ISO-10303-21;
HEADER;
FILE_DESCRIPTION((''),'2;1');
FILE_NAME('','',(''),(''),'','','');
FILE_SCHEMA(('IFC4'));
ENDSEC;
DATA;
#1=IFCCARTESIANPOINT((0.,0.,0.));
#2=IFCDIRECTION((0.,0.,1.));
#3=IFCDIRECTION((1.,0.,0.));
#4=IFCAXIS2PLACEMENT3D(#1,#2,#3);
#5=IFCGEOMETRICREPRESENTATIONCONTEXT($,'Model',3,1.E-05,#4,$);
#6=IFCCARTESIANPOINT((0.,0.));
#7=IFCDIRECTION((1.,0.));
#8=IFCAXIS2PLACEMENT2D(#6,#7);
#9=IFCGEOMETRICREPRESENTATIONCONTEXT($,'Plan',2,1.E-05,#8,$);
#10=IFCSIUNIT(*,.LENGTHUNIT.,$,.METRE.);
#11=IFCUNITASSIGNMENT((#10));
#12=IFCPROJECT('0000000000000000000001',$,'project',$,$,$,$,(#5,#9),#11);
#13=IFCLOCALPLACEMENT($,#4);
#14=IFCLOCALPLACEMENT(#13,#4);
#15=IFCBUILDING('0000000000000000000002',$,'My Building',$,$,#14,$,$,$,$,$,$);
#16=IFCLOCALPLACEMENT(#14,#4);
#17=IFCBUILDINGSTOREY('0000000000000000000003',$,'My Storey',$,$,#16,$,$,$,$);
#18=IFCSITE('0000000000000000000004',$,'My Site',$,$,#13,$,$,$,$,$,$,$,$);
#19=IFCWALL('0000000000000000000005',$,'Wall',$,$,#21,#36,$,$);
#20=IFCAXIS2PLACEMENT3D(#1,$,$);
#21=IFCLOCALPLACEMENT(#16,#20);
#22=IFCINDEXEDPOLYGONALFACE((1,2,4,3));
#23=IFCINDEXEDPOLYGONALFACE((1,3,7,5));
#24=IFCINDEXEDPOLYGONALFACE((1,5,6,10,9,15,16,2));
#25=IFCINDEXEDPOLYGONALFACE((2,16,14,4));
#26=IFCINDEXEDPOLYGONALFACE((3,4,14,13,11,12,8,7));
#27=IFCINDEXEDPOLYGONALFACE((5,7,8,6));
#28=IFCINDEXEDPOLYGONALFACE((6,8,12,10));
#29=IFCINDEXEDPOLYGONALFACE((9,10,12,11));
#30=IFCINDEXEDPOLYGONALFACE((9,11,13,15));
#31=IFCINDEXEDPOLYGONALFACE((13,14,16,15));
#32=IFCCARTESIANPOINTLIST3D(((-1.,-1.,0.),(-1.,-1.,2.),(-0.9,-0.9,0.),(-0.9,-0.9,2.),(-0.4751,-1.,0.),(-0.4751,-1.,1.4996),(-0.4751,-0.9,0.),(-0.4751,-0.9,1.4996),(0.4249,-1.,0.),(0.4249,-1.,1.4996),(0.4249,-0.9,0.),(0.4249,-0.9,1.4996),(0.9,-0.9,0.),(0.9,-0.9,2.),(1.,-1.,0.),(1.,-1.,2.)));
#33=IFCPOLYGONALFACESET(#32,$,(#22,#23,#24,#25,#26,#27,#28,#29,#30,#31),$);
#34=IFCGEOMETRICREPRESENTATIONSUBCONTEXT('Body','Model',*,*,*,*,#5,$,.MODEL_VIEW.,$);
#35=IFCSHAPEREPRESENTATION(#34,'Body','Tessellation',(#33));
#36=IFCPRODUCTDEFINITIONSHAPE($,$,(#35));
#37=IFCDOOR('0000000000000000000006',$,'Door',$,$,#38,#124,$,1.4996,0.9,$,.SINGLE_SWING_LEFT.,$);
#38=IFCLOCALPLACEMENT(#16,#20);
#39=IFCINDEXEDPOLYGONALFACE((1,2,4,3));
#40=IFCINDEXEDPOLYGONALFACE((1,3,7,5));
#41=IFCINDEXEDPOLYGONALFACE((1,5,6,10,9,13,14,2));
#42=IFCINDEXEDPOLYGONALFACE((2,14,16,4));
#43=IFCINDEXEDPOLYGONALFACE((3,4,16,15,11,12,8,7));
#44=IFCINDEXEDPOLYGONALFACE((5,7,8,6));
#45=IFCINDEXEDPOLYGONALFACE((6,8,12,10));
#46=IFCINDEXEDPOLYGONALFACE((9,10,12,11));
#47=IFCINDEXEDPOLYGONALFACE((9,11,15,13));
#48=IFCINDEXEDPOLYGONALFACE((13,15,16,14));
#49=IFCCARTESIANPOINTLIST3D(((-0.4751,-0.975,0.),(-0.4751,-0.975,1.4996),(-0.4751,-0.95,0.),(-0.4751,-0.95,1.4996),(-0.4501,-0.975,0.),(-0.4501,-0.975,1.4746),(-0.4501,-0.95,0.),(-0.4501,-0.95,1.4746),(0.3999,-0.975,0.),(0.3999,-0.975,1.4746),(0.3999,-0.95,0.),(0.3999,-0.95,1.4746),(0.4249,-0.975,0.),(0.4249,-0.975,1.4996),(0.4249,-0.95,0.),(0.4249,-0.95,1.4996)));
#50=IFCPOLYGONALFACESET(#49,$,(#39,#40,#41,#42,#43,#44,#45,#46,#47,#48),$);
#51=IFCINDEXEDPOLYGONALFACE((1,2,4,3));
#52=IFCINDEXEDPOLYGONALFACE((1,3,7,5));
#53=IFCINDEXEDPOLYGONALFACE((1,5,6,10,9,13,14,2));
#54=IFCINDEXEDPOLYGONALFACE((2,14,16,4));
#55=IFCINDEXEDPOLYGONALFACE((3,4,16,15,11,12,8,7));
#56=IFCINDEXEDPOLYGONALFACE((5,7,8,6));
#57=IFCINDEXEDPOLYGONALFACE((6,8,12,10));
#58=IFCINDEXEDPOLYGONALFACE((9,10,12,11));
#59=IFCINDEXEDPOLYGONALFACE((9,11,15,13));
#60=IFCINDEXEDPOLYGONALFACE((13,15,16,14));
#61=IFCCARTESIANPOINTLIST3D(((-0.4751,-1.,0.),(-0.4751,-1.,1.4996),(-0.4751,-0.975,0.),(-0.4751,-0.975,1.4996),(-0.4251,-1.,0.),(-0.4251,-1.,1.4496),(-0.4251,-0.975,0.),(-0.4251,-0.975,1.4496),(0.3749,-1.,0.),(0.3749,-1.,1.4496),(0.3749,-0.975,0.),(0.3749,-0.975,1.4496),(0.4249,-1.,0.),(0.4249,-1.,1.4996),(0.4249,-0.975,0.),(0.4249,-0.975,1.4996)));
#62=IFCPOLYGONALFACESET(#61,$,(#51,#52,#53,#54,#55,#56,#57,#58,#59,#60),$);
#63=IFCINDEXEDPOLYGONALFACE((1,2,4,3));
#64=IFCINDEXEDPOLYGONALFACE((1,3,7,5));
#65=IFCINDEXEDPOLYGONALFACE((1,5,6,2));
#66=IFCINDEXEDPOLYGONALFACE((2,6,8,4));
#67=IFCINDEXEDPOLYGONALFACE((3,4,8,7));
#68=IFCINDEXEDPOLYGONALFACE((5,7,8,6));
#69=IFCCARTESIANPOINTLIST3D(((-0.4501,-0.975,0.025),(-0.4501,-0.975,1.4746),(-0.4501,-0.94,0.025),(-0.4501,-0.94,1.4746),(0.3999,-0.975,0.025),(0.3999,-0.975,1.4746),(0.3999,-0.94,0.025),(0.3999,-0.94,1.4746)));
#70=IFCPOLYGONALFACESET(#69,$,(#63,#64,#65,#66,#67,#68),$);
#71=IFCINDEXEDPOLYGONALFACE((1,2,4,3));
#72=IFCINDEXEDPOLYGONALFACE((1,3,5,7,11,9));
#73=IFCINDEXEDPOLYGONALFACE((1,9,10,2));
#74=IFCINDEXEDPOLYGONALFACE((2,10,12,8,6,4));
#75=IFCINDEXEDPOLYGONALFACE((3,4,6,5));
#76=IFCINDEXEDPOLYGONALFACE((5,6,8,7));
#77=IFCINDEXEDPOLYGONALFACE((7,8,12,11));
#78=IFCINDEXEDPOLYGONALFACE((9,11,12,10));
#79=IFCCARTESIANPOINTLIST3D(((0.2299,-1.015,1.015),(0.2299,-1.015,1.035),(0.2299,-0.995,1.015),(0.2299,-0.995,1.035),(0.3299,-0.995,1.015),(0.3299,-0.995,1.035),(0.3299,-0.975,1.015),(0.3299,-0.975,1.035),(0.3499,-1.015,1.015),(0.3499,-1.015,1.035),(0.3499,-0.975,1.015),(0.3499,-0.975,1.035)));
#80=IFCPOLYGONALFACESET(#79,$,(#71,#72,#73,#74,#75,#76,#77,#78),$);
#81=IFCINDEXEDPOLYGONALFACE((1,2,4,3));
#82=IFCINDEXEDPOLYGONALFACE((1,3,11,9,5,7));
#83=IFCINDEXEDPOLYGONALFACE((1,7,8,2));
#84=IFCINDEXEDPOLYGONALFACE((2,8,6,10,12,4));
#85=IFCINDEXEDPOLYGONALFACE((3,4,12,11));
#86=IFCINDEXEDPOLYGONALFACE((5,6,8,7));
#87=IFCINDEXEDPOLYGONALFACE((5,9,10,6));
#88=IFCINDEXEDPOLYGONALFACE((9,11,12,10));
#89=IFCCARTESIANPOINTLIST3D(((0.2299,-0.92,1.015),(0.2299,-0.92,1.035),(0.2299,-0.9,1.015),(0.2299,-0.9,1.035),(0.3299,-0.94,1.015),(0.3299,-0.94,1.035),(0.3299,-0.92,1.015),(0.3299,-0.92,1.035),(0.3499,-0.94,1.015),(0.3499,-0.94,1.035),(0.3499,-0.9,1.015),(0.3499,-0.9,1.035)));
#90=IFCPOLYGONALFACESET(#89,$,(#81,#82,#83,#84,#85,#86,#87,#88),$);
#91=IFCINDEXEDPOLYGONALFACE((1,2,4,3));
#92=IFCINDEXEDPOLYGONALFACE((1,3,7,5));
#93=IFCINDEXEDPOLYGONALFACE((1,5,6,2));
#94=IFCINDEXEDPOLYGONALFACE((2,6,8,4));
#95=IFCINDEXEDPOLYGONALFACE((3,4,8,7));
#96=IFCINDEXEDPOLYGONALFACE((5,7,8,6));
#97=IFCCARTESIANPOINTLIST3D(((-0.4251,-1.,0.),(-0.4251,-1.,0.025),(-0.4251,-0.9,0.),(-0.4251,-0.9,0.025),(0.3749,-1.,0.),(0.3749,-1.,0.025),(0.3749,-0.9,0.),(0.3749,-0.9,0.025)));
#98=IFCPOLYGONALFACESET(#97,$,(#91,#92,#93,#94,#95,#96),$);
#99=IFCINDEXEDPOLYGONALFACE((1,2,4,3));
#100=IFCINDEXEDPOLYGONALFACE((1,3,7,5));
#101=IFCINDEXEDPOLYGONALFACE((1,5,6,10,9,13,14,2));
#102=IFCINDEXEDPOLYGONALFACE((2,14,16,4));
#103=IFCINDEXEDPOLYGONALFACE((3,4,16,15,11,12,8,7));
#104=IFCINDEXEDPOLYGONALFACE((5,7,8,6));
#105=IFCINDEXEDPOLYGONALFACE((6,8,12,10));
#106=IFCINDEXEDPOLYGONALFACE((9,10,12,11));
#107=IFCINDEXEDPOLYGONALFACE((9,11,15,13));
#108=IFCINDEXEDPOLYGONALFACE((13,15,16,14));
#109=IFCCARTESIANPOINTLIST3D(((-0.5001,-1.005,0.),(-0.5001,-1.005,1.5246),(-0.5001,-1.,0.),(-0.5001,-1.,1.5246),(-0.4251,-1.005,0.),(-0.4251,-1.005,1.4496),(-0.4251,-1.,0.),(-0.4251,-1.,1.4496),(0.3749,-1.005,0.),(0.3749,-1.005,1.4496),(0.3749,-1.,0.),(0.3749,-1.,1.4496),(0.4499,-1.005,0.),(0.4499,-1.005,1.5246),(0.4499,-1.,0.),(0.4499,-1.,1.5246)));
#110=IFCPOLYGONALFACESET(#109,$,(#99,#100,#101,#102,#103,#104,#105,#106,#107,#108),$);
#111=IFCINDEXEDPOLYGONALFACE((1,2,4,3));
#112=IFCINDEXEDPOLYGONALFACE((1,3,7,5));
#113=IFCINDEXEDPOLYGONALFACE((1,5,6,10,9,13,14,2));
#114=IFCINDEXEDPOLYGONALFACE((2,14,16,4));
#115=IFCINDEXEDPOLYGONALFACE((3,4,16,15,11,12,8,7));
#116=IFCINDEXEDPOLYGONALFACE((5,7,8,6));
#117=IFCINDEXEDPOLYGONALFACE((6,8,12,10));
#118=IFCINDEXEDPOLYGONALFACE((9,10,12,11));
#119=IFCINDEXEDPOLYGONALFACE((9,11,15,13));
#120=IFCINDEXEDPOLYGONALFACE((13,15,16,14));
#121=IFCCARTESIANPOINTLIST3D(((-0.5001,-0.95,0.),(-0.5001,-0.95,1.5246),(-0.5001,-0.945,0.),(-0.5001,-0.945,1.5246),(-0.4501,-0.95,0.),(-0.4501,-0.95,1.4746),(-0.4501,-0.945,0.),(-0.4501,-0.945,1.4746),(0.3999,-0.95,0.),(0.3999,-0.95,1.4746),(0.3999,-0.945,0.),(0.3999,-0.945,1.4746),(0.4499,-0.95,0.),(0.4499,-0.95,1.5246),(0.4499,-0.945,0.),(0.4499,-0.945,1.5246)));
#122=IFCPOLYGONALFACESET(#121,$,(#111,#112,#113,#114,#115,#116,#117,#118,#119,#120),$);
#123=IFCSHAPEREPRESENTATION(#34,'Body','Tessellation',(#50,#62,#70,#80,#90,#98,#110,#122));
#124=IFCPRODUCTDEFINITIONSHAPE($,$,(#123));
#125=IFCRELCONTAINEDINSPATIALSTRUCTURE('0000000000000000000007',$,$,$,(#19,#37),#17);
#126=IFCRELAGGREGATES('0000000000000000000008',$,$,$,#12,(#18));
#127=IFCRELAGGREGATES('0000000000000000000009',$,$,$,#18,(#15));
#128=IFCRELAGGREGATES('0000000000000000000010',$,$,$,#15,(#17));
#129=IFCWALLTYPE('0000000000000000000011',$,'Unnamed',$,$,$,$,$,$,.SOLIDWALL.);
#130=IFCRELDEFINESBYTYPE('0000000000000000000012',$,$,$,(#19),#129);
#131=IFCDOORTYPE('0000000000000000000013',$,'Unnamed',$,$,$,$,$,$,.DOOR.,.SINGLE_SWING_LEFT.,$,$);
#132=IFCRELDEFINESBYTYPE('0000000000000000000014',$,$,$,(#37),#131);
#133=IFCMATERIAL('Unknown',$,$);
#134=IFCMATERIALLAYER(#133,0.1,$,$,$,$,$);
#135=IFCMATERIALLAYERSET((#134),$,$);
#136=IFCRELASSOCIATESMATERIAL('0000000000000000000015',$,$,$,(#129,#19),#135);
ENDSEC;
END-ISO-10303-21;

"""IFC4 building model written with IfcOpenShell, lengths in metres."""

from ifc_helpers import new_model, entity, si_unit, frame, origin_with_axes, origin_2d_with_axis, place, context, subcontext, project, spatial, line, indexed_curve, outline, extrude, shape, source, transform, mapped, material, layer, layer_set, layer_usage, type_object, type_shapes, element, fill, save


model = new_model("IFC4")

# Units and contexts
model_context = context("Model", 3, precision=1e-05, world=origin_with_axes())
plan_context = context("Plan", 2, precision=1e-05, world=origin_2d_with_axis())
body_context_1 = subcontext(model_context, "Body", "Model", "MODEL_VIEW")
body_context_2 = subcontext(plan_context, "Body", "Plan", "PLAN_VIEW")
ifc_project = project(units=[si_unit("LENGTHUNIT", "METRE")], contexts=[model_context, plan_context])

# Site, building, storey
site_placement = place(None, origin_with_axes())
site = spatial("IfcSite", under=ifc_project, at=site_placement, Name="My Site")
building_placement = place(site_placement, origin_with_axes())
building = spatial("IfcBuilding", under=site, at=building_placement, Name="My Building")
storey_placement = place(building_placement, origin_with_axes())
storey = spatial("IfcBuildingStorey", under=building, at=storey_placement, Name="My Storey")

# Shared definitions
ifc_material = material(Name="Unknown")

# Shared definitions
ifc_layer = layer(ifc_material, 0.1)
ifc_layer_set = layer_set([ifc_layer])
wall_type = type_object("IfcWallType", Name="Unnamed", PredefinedType="SOLIDWALL", material=ifc_layer_set)

# Wall, opening, door
ifc_layer_usage_1 = layer_usage(ifc_layer_set, "AXIS2", "POSITIVE", 0.0)
wall_1_placement = place(storey_placement, frame((0.9, -0.9, 0.0), z_axis=(0.0, 0.0, 1.0), x_axis=(-1.0, 0.0, 0.0)))
wall_1 = element("IfcWall", 1, at=wall_1_placement, inside=storey, type_object=wall_type, material=ifc_layer_usage_1, Name="Wall", context=body_context_1, shape_type="SweptSolid", body=[
    extrude(outline(indexed_curve([(0.0, 0.0), (-0.1, 0.1), (1.9, 0.1), (1.8, 0.0)], segments=[line(1, 2, 3, 4, 1)])), origin_with_axes(), (0.0, 0.0, 1.0), 2.0),
])
shared_shape_1 = source(origin_with_axes(), body_context_1, "Body", "SweptSolid", [
    extrude(outline(indexed_curve([(0.0, 0.0), (0.9, 0.0), (0.9, 1.4996), (0.0, 1.4996)], segments=[line(1, 2, 3, 4, 1)])), frame((0.0, -0.6, 0.0), z_axis=(0.0, -1.0, 0.0), x_axis=(1.0, 0.0, 0.0)), (0.0, 0.0, -1.0), 1.2),
])
opening_1_placement = place(wall_1_placement, frame((1.3751, 0.1, 0.0), z_axis=(0.0, 0.0, 1.0), x_axis=(-1.0, 0.0, 0.0)))
opening_1 = element("IfcOpeningElement", 2, at=opening_1_placement, cuts=wall_1, PredefinedType="OPENING", context=body_context_1, shape_type="MappedRepresentation", body=[
    mapped(shared_shape_1, transform((0.0, 0.0, 0.0), x_axis=(1.0, 0.0, 0.0), y_axis=(0.0, 1.0, 0.0), z_axis=(0.0, 0.0, 1.0), scale=1.0)),
])
door_type = type_object("IfcDoorType", Name="Unnamed", OperationType="SINGLE_SWING_LEFT", PredefinedType="DOOR")
shared_shape_2 = source(origin_with_axes(), body_context_1, "Body", "SweptSolid", [
    extrude(outline(indexed_curve([(0.0, 0.0), (0.0, 1.4996), (0.9, 1.4996), (0.9, 0.0), (0.875, 0.0), (0.875, 1.4746), (0.025, 1.4746), (0.025, 0.0)], segments=[line(1, 2, 3, 4, 5, 6, 7, 8, 1)])), frame((0.0, 0.025, 0.0), z_axis=(0.0, -1.0, 0.0), x_axis=(1.0, 0.0, 0.0)), (0.0, 0.0, -1.0), 0.025),
    extrude(outline(indexed_curve([(0.0, 0.0), (0.0, 1.4996), (0.9, 1.4996), (0.9, 0.0), (0.85, 0.0), (0.85, 1.4496), (0.05, 1.4496), (0.05, 0.0)], segments=[line(1, 2, 3, 4, 5, 6, 7, 8, 1)])), frame((0.0, 0.0, 0.0), z_axis=(0.0, -1.0, 0.0), x_axis=(1.0, 0.0, 0.0)), (0.0, 0.0, -1.0), 0.025),
    extrude(outline(indexed_curve([(0.0, 0.0), (0.85, 0.0), (0.85, 0.035), (0.0, 0.035)], segments=[line(1, 2, 3, 4, 1)])), frame((0.025, 0.025, 0.025), z_axis=(0.0, 0.0, 1.0), x_axis=(1.0, 0.0, 0.0)), (0.0, 0.0, 1.0), 1.4496),
    extrude(outline(indexed_curve([(0.0, 0.0), (0.0, -0.04), (-0.12, -0.04), (-0.12, -0.02), (-0.02, -0.02), (-0.02, 0.0)], segments=[line(1, 2, 3, 4, 5, 6, 1)])), frame((0.825, 0.025, 1.015), z_axis=(0.0, 0.0, 1.0), x_axis=(1.0, 0.0, 0.0)), (0.0, 0.0, 1.0), 0.02),
    extrude(outline(indexed_curve([(0.0, 0.0), (0.0, 0.04), (-0.12, 0.04), (-0.12, 0.02), (-0.02, 0.02), (-0.02, 0.0)], segments=[line(1, 2, 3, 4, 5, 6, 1)])), frame((0.825, 0.06, 1.015), z_axis=(0.0, 0.0, 1.0), x_axis=(1.0, 0.0, 0.0)), (0.0, 0.0, 1.0), 0.02),
    extrude(outline(indexed_curve([(0.0, 0.0), (0.8, 0.0), (0.8, 0.1), (0.0, 0.1)], segments=[line(1, 2, 3, 4, 1)])), frame((0.05, 0.0, 0.0), z_axis=(0.0, 0.0, 1.0), x_axis=(1.0, 0.0, 0.0)), (0.0, 0.0, 1.0), 0.025),
    extrude(outline(indexed_curve([(0.0, 0.0), (0.0, 1.5246), (0.95, 1.5246), (0.95, 0.0), (0.875, 0.0), (0.875, 1.4496), (0.075, 1.4496), (0.075, 0.0)], segments=[line(1, 2, 3, 4, 5, 6, 7, 8, 1)])), frame((-0.025, -0.005, 0.0), z_axis=(0.0, -1.0, 0.0), x_axis=(1.0, 0.0, 0.0)), (0.0, 0.0, -1.0), 0.005),
    extrude(outline(indexed_curve([(0.0, 0.0), (0.0, 1.5246), (0.95, 1.5246), (0.95, 0.0), (0.9, 0.0), (0.9, 1.4746), (0.05, 1.4746), (0.05, 0.0)], segments=[line(1, 2, 3, 4, 5, 6, 7, 8, 1)])), frame((-0.025, 0.05, 0.0), z_axis=(0.0, -1.0, 0.0), x_axis=(1.0, 0.0, 0.0)), (0.0, 0.0, -1.0), 0.005),
])
shared_shape_3 = source(origin_with_axes(), body_context_2, "Body", "Curve2D", [
    entity("IfcIndexedPolyCurve", entity("IfcCartesianPointList2D", [[0.0, 0.0], [0.0, 0.05], [0.025, 0.05], [0.025, 0.025], [0.05, 0.025], [0.05, 0.0]]), [entity("IfcLineIndex", [1, 2, 3, 4, 5, 6, 1])]),
    entity("IfcIndexedPolyCurve", entity("IfcCartesianPointList2D", [[0.9, 0.0], [0.9, 0.05], [0.875, 0.05], [0.875, 0.025], [0.85, 0.025], [0.85, 0.0]]), [entity("IfcLineIndex", [1, 2, 3, 4, 5, 6, 1])]),
    entity("IfcTrimmedCurve", entity("IfcEllipse", entity("IfcAxis2Placement2D", entity("IfcCartesianPoint", [0.06, 0.05]), entity("IfcDirection", [1.0, 0.0])), 0.815, 0.85), [entity("IfcCartesianPoint", [0.875, 0.05])], [entity("IfcCartesianPoint", [0.06, 0.9])], True, "CARTESIAN"),
    entity("IfcIndexedPolyCurve", entity("IfcCartesianPointList2D", [[0.025, 0.05], [0.06, 0.05], [0.06, 0.9], [0.025, 0.9]]), [entity("IfcLineIndex", [1, 2, 3, 4, 1])]),
])
type_shapes(door_type, [shared_shape_2, shared_shape_3])
door_placement = place(opening_1_placement, frame((0.0, 0.0, 0.0), z_axis=(0.0, 0.0, 1.0), x_axis=(1.0, 0.0, 0.0)))
door = element("IfcDoor", 3, at=door_placement, inside=storey, type_object=door_type, Name="Door", OperationType="SINGLE_SWING_LEFT", OverallHeight=1.4996, OverallWidth=0.9, shapes=[
    shape(body_context_1, "Body", "MappedRepresentation", [mapped(shared_shape_2, transform((0.0, 0.0, 0.0), x_axis=(1.0, 0.0, 0.0), y_axis=(0.0, 1.0, 0.0), z_axis=(0.0, 0.0, 1.0), scale=1.0))]),
    shape(body_context_2, "Body", "MappedRepresentation", [mapped(shared_shape_3, transform((0.0, 0.0, 0.0), x_axis=(1.0, 0.0, 0.0), y_axis=(0.0, 1.0, 0.0), z_axis=(0.0, 0.0, 1.0), scale=1.0))]),
])
fill(opening_1, door)

save(model, "model.ifc")
